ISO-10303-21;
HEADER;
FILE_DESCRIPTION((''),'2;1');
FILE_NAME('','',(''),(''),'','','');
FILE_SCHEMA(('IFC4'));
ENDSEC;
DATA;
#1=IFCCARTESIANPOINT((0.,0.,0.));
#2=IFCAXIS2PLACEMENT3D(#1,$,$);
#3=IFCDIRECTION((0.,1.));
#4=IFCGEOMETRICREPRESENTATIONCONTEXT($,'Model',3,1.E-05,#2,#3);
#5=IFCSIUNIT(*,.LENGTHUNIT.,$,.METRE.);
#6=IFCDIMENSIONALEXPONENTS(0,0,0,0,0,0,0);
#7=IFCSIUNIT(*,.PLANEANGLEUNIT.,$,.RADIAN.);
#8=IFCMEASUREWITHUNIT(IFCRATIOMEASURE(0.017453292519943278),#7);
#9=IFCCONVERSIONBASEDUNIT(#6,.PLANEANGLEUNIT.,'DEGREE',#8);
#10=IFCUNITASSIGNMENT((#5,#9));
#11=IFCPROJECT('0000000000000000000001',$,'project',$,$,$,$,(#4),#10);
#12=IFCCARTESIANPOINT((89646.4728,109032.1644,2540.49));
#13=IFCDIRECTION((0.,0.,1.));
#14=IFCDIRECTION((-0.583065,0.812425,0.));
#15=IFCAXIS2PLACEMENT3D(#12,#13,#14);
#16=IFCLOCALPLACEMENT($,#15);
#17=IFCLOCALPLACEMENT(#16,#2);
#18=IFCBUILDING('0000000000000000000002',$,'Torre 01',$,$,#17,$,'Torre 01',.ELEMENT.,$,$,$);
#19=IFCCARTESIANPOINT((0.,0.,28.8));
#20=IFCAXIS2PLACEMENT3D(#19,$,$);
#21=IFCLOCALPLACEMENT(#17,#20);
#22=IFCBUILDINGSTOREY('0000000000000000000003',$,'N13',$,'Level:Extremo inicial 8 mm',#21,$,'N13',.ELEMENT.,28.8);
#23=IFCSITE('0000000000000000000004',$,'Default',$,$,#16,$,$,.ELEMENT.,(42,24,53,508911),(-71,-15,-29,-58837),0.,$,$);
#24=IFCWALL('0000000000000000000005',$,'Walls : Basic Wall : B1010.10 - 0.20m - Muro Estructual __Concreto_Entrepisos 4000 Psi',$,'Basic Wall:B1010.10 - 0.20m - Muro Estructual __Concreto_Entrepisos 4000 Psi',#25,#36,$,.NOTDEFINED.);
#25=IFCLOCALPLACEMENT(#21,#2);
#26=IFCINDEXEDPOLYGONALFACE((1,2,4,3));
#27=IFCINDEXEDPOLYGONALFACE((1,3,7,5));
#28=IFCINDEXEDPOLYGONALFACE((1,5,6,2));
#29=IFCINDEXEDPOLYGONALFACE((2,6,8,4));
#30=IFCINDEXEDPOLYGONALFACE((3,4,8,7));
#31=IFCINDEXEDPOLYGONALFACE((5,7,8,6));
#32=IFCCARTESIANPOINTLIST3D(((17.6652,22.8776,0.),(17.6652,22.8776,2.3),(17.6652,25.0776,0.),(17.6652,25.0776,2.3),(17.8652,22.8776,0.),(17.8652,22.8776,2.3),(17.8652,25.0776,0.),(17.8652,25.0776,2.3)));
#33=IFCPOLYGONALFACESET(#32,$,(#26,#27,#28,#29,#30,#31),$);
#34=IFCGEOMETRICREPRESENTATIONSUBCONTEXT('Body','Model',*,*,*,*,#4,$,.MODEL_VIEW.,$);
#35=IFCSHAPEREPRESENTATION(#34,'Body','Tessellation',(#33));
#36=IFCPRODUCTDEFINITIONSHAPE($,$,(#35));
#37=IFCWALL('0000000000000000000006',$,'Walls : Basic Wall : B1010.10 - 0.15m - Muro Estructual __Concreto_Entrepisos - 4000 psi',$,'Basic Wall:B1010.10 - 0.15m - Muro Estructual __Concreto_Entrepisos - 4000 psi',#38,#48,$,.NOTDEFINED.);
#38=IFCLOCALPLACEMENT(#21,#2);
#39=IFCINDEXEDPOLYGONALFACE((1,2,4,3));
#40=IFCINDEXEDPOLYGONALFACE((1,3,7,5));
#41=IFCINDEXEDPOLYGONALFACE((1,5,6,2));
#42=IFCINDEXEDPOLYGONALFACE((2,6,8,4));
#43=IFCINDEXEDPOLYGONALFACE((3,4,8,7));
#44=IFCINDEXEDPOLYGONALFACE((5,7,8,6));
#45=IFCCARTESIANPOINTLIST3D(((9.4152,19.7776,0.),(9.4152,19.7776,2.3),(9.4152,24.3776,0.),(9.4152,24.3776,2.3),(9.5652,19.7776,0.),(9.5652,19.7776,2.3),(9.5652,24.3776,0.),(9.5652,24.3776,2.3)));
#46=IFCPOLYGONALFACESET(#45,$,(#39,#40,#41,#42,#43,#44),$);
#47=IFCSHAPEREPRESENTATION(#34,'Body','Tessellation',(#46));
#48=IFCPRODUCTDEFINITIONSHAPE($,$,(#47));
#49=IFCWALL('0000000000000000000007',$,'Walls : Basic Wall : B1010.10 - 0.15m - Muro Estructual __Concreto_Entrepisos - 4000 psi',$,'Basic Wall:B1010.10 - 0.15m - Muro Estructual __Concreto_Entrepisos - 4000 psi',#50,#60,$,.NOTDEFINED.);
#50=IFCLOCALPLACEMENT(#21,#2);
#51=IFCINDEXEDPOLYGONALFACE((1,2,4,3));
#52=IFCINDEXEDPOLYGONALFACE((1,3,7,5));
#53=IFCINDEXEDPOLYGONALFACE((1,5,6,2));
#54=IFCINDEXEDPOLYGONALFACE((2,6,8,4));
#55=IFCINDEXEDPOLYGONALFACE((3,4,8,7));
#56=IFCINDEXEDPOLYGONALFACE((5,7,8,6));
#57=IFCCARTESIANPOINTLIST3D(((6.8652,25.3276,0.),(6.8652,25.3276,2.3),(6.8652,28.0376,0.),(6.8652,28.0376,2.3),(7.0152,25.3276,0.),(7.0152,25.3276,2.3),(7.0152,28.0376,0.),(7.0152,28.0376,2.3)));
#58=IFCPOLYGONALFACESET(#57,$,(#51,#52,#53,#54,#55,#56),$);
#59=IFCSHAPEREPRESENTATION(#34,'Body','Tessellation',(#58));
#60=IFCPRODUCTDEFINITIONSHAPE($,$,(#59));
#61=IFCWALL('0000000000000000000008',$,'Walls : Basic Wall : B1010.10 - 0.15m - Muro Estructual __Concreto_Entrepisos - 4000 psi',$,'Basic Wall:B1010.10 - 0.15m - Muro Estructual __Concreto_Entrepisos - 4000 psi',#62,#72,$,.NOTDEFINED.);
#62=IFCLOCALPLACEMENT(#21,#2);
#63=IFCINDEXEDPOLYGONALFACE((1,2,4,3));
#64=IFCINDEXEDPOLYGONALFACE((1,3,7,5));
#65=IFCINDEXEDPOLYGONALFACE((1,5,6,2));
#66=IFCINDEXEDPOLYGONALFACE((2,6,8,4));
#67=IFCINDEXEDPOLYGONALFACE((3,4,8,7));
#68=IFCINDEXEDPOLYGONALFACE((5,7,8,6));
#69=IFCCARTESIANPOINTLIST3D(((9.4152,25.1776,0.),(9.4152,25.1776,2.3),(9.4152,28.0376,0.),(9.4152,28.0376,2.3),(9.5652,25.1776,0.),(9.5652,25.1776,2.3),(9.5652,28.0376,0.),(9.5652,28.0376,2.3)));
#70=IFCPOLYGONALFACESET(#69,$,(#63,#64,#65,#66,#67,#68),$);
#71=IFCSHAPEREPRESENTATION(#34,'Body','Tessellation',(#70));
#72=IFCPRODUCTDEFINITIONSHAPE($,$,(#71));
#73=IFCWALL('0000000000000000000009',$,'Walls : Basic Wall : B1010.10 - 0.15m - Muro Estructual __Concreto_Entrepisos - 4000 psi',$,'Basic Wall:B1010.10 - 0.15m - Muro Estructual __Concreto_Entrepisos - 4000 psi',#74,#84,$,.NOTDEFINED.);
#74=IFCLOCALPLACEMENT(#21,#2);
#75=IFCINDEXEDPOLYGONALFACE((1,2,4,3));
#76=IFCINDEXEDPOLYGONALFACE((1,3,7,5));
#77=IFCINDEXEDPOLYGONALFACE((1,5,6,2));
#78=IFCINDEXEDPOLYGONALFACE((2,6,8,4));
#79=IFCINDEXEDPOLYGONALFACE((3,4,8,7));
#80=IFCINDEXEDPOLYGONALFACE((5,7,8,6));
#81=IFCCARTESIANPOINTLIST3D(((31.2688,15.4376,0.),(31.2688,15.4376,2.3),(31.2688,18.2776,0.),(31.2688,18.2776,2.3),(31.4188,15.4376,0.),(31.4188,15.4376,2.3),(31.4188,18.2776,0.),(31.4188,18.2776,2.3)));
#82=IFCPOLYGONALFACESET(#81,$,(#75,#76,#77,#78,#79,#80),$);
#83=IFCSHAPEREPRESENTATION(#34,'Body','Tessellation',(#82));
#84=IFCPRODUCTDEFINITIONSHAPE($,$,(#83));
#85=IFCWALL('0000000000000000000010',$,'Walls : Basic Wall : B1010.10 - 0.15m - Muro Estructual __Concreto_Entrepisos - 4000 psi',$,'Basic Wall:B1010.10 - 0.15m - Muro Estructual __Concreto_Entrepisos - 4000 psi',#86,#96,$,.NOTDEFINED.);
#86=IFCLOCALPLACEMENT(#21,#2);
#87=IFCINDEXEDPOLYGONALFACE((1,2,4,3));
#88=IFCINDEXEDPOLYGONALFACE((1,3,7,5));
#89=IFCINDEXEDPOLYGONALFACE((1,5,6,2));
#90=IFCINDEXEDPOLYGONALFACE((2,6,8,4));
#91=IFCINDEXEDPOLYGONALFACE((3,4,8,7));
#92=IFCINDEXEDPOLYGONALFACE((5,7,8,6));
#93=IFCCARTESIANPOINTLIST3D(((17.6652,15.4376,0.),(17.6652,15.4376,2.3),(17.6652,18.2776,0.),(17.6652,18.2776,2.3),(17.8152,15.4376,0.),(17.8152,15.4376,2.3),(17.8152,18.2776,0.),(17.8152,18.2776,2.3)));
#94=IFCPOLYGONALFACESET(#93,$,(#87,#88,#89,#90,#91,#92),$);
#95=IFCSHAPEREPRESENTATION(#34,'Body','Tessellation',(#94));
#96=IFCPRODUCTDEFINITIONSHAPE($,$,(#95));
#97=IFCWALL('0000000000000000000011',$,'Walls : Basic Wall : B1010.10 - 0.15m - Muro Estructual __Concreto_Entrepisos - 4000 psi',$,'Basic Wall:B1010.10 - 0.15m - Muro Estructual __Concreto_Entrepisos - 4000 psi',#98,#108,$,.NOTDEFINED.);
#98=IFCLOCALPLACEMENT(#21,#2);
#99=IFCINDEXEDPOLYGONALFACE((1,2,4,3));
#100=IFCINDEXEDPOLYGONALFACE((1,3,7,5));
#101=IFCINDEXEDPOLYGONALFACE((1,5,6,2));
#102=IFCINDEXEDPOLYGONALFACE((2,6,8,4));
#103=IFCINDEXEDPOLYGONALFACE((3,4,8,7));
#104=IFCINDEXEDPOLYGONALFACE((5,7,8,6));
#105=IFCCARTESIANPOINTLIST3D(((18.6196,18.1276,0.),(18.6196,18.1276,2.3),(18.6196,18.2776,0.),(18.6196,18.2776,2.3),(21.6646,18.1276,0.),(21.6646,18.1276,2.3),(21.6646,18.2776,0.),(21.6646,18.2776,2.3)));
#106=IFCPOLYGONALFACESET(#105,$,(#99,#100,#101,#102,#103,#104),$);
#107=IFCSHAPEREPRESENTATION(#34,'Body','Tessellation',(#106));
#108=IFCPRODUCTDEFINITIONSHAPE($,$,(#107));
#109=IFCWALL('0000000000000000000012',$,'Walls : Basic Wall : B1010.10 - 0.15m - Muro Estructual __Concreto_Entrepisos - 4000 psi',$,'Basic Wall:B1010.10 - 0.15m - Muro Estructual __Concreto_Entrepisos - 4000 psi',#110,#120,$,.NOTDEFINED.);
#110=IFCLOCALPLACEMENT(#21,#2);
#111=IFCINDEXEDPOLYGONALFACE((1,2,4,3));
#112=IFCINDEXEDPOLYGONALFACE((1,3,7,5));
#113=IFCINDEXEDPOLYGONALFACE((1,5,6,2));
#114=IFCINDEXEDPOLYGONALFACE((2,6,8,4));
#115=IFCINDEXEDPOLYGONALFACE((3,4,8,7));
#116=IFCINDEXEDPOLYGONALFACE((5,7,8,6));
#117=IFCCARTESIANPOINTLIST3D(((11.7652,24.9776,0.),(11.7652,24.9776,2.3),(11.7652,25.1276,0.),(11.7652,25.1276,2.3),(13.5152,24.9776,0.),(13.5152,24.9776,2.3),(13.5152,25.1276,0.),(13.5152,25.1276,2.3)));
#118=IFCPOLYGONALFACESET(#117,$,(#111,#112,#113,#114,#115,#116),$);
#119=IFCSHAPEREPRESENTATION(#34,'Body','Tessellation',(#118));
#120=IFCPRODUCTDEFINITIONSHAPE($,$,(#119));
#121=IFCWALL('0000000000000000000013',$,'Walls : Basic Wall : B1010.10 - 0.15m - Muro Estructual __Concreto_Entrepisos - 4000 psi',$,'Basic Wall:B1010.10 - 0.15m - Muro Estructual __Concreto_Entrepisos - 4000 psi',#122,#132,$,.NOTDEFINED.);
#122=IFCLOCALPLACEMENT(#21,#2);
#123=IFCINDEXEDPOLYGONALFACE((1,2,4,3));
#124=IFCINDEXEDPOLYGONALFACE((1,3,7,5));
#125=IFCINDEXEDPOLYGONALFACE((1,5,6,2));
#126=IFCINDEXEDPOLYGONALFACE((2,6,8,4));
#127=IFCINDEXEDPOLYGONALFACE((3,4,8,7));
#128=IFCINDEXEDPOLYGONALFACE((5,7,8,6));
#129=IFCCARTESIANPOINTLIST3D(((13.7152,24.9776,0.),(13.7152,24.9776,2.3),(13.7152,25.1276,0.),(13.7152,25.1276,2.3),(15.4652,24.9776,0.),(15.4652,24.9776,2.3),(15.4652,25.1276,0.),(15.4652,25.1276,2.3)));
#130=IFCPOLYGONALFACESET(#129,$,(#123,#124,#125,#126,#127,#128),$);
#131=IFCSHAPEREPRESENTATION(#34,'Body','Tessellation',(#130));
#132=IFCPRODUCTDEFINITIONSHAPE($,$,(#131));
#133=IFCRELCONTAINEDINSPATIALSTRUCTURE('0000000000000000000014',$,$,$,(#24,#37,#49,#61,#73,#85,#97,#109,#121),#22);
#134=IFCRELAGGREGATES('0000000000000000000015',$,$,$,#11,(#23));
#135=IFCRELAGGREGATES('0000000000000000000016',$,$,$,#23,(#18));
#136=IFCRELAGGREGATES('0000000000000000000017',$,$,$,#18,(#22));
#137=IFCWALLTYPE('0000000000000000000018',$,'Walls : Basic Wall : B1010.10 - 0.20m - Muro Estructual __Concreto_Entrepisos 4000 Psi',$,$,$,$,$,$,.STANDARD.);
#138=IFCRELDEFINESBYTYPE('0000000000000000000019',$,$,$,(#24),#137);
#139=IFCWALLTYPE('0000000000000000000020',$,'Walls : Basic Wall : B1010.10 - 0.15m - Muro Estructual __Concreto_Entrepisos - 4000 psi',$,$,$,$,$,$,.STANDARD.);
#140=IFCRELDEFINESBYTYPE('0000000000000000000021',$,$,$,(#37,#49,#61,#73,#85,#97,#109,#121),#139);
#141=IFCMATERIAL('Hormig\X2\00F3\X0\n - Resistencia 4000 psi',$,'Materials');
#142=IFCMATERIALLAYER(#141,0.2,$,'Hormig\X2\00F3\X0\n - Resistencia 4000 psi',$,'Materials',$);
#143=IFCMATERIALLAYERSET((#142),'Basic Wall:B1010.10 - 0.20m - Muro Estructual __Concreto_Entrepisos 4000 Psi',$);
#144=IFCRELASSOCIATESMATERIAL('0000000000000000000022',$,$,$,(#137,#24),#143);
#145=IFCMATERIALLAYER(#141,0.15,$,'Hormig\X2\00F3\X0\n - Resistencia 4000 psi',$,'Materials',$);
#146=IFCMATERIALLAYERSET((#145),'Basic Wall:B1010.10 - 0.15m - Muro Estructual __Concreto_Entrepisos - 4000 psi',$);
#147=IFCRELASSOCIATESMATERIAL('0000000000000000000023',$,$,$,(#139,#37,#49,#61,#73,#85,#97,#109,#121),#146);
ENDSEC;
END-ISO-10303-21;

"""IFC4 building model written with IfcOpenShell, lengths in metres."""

from ifc_helpers import new_model, entity, si_unit, converted_unit, direction, frame, frame_2d, origin, place, context, subcontext, project, spatial, rectangle, extrude, material, layer, layer_set, layer_usage, type_object, element, save


model = new_model("IFC4")

# Units and contexts
model_context = context("Model", 3, precision=1e-05, world=origin(), true_north=direction((0.0, 1.0)))
body_context = subcontext(model_context, "Body", "Model", "MODEL_VIEW")
ifc_project = project(units=[si_unit("LENGTHUNIT", "METRE"), converted_unit("PLANEANGLEUNIT", "DEGREE", entity("IfcRatioMeasure", 0.017453292519943278), si_unit("PLANEANGLEUNIT", "RADIAN"), dimensions=[0, 0, 0, 0, 0, 0, 0])], contexts=[model_context])

# Site, building, storey
site_placement = place(None, frame((89646.4728, 109032.1644, 2540.49), z_axis=(0.0, 0.0, 1.0), x_axis=(-0.583065, 0.812425, 0.0)))
site = spatial("IfcSite", under=ifc_project, at=site_placement, Name="Default", CompositionType="ELEMENT", RefLatitude=(42, 24, 53, 508911), RefLongitude=(-71, -15, -29, -58837), RefElevation=0.0)
building_placement = place(site_placement, origin())
building = spatial("IfcBuilding", under=site, at=building_placement, Name="Torre 01", LongName="Torre 01", CompositionType="ELEMENT")
storey_placement = place(building_placement, frame((0.0, 0.0, 28.8)))
storey = spatial("IfcBuildingStorey", under=building, at=storey_placement, Name="N13", ObjectType="Level:Extremo inicial 8 mm", LongName="N13", CompositionType="ELEMENT", Elevation=28.8)

# Walls
ifc_material = material(Name="Hormigón - Resistencia 4000 psi", Category="Materials")
ifc_layer_1 = layer(ifc_material, 0.2, Name="Hormigón - Resistencia 4000 psi", Category="Materials")
ifc_layer_set_1 = layer_set([ifc_layer_1], Name="Basic Wall:B1010.10 - 0.20m - Muro Estructual __Concreto_Entrepisos 4000 Psi")
wall_type_1 = type_object("IfcWallType", Name="Walls : Basic Wall : B1010.10 - 0.20m - Muro Estructual __Concreto_Entrepisos 4000 Psi", PredefinedType="STANDARD", material=ifc_layer_set_1)
ifc_layer_usage_1 = layer_usage(ifc_layer_set_1, "AXIS2", "NEGATIVE", 0.1)
wall_1_placement = place(storey_placement, frame((17.7652, 22.8776, 0.0), z_axis=(0.0, 0.0, 1.0), x_axis=(0.0, 1.0, 0.0)))
element("IfcWall", 1, at=wall_1_placement, inside=storey, type_object=wall_type_1, material=ifc_layer_usage_1, Name="Walls : Basic Wall : B1010.10 - 0.20m - Muro Estructual __Concreto_Entrepisos 4000 Psi", ObjectType="Basic Wall:B1010.10 - 0.20m - Muro Estructual __Concreto_Entrepisos 4000 Psi", PredefinedType="NOTDEFINED", context=body_context, shape_type="SweptSolid", body=[
    extrude(rectangle(XDim=2.2, YDim=0.2, at=frame_2d((1.1, 0.0), x_axis=(-1.0, 0.0))), origin(), (0.0, 0.0, 1.0), 2.3),
])
ifc_layer_2 = layer(ifc_material, 0.15, Name="Hormigón - Resistencia 4000 psi", Category="Materials")
ifc_layer_set_2 = layer_set([ifc_layer_2], Name="Basic Wall:B1010.10 - 0.15m - Muro Estructual __Concreto_Entrepisos - 4000 psi")
ifc_layer_usage_2 = layer_usage(ifc_layer_set_2, "AXIS2", "NEGATIVE", 0.075)
wall_type_2 = type_object("IfcWallType", Name="Walls : Basic Wall : B1010.10 - 0.15m - Muro Estructual __Concreto_Entrepisos - 4000 psi", PredefinedType="STANDARD", material=ifc_layer_set_2)
wall_2_placement = place(storey_placement, frame((9.4902, 24.3776, 0.0), z_axis=(0.0, 0.0, 1.0), x_axis=(0.0, -1.0, 0.0)))
element("IfcWall", 2, at=wall_2_placement, inside=storey, type_object=wall_type_2, material=ifc_layer_usage_2, Name="Walls : Basic Wall : B1010.10 - 0.15m - Muro Estructual __Concreto_Entrepisos - 4000 psi", ObjectType="Basic Wall:B1010.10 - 0.15m - Muro Estructual __Concreto_Entrepisos - 4000 psi", PredefinedType="NOTDEFINED", context=body_context, shape_type="SweptSolid", body=[
    extrude(rectangle(XDim=4.6, YDim=0.15, at=frame_2d((2.3, 0.0), x_axis=(-1.0, 0.0))), origin(), (0.0, 0.0, 1.0), 2.3),
])
ifc_layer_usage_3 = layer_usage(ifc_layer_set_2, "AXIS2", "NEGATIVE", 0.075)
wall_3_placement = place(storey_placement, frame((6.9402, 25.3276, 0.0), z_axis=(0.0, 0.0, 1.0), x_axis=(0.0, 1.0, 0.0)))
element("IfcWall", 3, at=wall_3_placement, inside=storey, type_object=wall_type_2, material=ifc_layer_usage_3, Name="Walls : Basic Wall : B1010.10 - 0.15m - Muro Estructual __Concreto_Entrepisos - 4000 psi", ObjectType="Basic Wall:B1010.10 - 0.15m - Muro Estructual __Concreto_Entrepisos - 4000 psi", PredefinedType="NOTDEFINED", context=body_context, shape_type="SweptSolid", body=[
    extrude(rectangle(XDim=2.71, YDim=0.15, at=frame_2d((1.355, 0.0), x_axis=(-1.0, 0.0))), origin(), (0.0, 0.0, 1.0), 2.3),
])
ifc_layer_usage_4 = layer_usage(ifc_layer_set_2, "AXIS2", "NEGATIVE", 0.075)
wall_4_placement = place(storey_placement, frame((9.4902, 28.0376, 0.0), z_axis=(0.0, 0.0, 1.0), x_axis=(0.0, -1.0, 0.0)))
element("IfcWall", 4, at=wall_4_placement, inside=storey, type_object=wall_type_2, material=ifc_layer_usage_4, Name="Walls : Basic Wall : B1010.10 - 0.15m - Muro Estructual __Concreto_Entrepisos - 4000 psi", ObjectType="Basic Wall:B1010.10 - 0.15m - Muro Estructual __Concreto_Entrepisos - 4000 psi", PredefinedType="NOTDEFINED", context=body_context, shape_type="SweptSolid", body=[
    extrude(rectangle(XDim=2.86, YDim=0.15, at=frame_2d((1.43, 0.0), x_axis=(-1.0, 0.0))), origin(), (0.0, 0.0, 1.0), 2.3),
])
ifc_layer_usage_5 = layer_usage(ifc_layer_set_2, "AXIS2", "NEGATIVE", 0.075)
wall_5_placement = place(storey_placement, frame((31.3438, 15.4376, 0.0), z_axis=(0.0, 0.0, 1.0), x_axis=(0.0, 1.0, 0.0)))
element("IfcWall", 5, at=wall_5_placement, inside=storey, type_object=wall_type_2, material=ifc_layer_usage_5, Name="Walls : Basic Wall : B1010.10 - 0.15m - Muro Estructual __Concreto_Entrepisos - 4000 psi", ObjectType="Basic Wall:B1010.10 - 0.15m - Muro Estructual __Concreto_Entrepisos - 4000 psi", PredefinedType="NOTDEFINED", context=body_context, shape_type="SweptSolid", body=[
    extrude(rectangle(XDim=2.84, YDim=0.15, at=frame_2d((1.42, 0.0), x_axis=(-1.0, 0.0))), origin(), (0.0, 0.0, 1.0), 2.3),
])
ifc_layer_usage_6 = layer_usage(ifc_layer_set_2, "AXIS2", "NEGATIVE", 0.075)
wall_6_placement = place(storey_placement, frame((17.7402, 18.2776, 0.0), z_axis=(0.0, 0.0, 1.0), x_axis=(0.0, -1.0, 0.0)))
element("IfcWall", 6, at=wall_6_placement, inside=storey, type_object=wall_type_2, material=ifc_layer_usage_6, Name="Walls : Basic Wall : B1010.10 - 0.15m - Muro Estructual __Concreto_Entrepisos - 4000 psi", ObjectType="Basic Wall:B1010.10 - 0.15m - Muro Estructual __Concreto_Entrepisos - 4000 psi", PredefinedType="NOTDEFINED", context=body_context, shape_type="SweptSolid", body=[
    extrude(rectangle(XDim=2.84, YDim=0.15, at=frame_2d((1.42, 0.0), x_axis=(-1.0, 0.0))), origin(), (0.0, 0.0, 1.0), 2.3),
])
ifc_layer_usage_7 = layer_usage(ifc_layer_set_2, "AXIS2", "NEGATIVE", 0.075)
wall_7_placement = place(storey_placement, frame((18.6196, 18.2026, 0.0)))
element("IfcWall", 7, at=wall_7_placement, inside=storey, type_object=wall_type_2, material=ifc_layer_usage_7, Name="Walls : Basic Wall : B1010.10 - 0.15m - Muro Estructual __Concreto_Entrepisos - 4000 psi", ObjectType="Basic Wall:B1010.10 - 0.15m - Muro Estructual __Concreto_Entrepisos - 4000 psi", PredefinedType="NOTDEFINED", context=body_context, shape_type="SweptSolid", body=[
    extrude(rectangle(XDim=3.045, YDim=0.15, at=frame_2d((1.5225, 0.0), x_axis=(-1.0, 0.0))), origin(), (0.0, 0.0, 1.0), 2.3),
])
ifc_layer_usage_8 = layer_usage(ifc_layer_set_2, "AXIS2", "POSITIVE", -0.075)
wall_8_placement = place(storey_placement, frame((11.7652, 25.0526, 0.0)))
element("IfcWall", 8, at=wall_8_placement, inside=storey, type_object=wall_type_2, material=ifc_layer_usage_8, Name="Walls : Basic Wall : B1010.10 - 0.15m - Muro Estructual __Concreto_Entrepisos - 4000 psi", ObjectType="Basic Wall:B1010.10 - 0.15m - Muro Estructual __Concreto_Entrepisos - 4000 psi", PredefinedType="NOTDEFINED", context=body_context, shape_type="SweptSolid", body=[
    extrude(rectangle(XDim=1.75, YDim=0.15, at=frame_2d((0.875, 0.0), x_axis=(-1.0, 0.0))), origin(), (0.0, 0.0, 1.0), 2.3),
])
ifc_layer_usage_9 = layer_usage(ifc_layer_set_2, "AXIS2", "POSITIVE", -0.075)
wall_9_placement = place(storey_placement, frame((13.7152, 25.0526, 0.0)))
element("IfcWall", 9, at=wall_9_placement, inside=storey, type_object=wall_type_2, material=ifc_layer_usage_9, Name="Walls : Basic Wall : B1010.10 - 0.15m - Muro Estructual __Concreto_Entrepisos - 4000 psi", ObjectType="Basic Wall:B1010.10 - 0.15m - Muro Estructual __Concreto_Entrepisos - 4000 psi", PredefinedType="NOTDEFINED", context=body_context, shape_type="SweptSolid", body=[
    extrude(rectangle(XDim=1.75, YDim=0.15, at=frame_2d((0.875, 0.0), x_axis=(-1.0, 0.0))), origin(), (0.0, 0.0, 1.0), 2.3),
])

save(model, "model.ifc")
